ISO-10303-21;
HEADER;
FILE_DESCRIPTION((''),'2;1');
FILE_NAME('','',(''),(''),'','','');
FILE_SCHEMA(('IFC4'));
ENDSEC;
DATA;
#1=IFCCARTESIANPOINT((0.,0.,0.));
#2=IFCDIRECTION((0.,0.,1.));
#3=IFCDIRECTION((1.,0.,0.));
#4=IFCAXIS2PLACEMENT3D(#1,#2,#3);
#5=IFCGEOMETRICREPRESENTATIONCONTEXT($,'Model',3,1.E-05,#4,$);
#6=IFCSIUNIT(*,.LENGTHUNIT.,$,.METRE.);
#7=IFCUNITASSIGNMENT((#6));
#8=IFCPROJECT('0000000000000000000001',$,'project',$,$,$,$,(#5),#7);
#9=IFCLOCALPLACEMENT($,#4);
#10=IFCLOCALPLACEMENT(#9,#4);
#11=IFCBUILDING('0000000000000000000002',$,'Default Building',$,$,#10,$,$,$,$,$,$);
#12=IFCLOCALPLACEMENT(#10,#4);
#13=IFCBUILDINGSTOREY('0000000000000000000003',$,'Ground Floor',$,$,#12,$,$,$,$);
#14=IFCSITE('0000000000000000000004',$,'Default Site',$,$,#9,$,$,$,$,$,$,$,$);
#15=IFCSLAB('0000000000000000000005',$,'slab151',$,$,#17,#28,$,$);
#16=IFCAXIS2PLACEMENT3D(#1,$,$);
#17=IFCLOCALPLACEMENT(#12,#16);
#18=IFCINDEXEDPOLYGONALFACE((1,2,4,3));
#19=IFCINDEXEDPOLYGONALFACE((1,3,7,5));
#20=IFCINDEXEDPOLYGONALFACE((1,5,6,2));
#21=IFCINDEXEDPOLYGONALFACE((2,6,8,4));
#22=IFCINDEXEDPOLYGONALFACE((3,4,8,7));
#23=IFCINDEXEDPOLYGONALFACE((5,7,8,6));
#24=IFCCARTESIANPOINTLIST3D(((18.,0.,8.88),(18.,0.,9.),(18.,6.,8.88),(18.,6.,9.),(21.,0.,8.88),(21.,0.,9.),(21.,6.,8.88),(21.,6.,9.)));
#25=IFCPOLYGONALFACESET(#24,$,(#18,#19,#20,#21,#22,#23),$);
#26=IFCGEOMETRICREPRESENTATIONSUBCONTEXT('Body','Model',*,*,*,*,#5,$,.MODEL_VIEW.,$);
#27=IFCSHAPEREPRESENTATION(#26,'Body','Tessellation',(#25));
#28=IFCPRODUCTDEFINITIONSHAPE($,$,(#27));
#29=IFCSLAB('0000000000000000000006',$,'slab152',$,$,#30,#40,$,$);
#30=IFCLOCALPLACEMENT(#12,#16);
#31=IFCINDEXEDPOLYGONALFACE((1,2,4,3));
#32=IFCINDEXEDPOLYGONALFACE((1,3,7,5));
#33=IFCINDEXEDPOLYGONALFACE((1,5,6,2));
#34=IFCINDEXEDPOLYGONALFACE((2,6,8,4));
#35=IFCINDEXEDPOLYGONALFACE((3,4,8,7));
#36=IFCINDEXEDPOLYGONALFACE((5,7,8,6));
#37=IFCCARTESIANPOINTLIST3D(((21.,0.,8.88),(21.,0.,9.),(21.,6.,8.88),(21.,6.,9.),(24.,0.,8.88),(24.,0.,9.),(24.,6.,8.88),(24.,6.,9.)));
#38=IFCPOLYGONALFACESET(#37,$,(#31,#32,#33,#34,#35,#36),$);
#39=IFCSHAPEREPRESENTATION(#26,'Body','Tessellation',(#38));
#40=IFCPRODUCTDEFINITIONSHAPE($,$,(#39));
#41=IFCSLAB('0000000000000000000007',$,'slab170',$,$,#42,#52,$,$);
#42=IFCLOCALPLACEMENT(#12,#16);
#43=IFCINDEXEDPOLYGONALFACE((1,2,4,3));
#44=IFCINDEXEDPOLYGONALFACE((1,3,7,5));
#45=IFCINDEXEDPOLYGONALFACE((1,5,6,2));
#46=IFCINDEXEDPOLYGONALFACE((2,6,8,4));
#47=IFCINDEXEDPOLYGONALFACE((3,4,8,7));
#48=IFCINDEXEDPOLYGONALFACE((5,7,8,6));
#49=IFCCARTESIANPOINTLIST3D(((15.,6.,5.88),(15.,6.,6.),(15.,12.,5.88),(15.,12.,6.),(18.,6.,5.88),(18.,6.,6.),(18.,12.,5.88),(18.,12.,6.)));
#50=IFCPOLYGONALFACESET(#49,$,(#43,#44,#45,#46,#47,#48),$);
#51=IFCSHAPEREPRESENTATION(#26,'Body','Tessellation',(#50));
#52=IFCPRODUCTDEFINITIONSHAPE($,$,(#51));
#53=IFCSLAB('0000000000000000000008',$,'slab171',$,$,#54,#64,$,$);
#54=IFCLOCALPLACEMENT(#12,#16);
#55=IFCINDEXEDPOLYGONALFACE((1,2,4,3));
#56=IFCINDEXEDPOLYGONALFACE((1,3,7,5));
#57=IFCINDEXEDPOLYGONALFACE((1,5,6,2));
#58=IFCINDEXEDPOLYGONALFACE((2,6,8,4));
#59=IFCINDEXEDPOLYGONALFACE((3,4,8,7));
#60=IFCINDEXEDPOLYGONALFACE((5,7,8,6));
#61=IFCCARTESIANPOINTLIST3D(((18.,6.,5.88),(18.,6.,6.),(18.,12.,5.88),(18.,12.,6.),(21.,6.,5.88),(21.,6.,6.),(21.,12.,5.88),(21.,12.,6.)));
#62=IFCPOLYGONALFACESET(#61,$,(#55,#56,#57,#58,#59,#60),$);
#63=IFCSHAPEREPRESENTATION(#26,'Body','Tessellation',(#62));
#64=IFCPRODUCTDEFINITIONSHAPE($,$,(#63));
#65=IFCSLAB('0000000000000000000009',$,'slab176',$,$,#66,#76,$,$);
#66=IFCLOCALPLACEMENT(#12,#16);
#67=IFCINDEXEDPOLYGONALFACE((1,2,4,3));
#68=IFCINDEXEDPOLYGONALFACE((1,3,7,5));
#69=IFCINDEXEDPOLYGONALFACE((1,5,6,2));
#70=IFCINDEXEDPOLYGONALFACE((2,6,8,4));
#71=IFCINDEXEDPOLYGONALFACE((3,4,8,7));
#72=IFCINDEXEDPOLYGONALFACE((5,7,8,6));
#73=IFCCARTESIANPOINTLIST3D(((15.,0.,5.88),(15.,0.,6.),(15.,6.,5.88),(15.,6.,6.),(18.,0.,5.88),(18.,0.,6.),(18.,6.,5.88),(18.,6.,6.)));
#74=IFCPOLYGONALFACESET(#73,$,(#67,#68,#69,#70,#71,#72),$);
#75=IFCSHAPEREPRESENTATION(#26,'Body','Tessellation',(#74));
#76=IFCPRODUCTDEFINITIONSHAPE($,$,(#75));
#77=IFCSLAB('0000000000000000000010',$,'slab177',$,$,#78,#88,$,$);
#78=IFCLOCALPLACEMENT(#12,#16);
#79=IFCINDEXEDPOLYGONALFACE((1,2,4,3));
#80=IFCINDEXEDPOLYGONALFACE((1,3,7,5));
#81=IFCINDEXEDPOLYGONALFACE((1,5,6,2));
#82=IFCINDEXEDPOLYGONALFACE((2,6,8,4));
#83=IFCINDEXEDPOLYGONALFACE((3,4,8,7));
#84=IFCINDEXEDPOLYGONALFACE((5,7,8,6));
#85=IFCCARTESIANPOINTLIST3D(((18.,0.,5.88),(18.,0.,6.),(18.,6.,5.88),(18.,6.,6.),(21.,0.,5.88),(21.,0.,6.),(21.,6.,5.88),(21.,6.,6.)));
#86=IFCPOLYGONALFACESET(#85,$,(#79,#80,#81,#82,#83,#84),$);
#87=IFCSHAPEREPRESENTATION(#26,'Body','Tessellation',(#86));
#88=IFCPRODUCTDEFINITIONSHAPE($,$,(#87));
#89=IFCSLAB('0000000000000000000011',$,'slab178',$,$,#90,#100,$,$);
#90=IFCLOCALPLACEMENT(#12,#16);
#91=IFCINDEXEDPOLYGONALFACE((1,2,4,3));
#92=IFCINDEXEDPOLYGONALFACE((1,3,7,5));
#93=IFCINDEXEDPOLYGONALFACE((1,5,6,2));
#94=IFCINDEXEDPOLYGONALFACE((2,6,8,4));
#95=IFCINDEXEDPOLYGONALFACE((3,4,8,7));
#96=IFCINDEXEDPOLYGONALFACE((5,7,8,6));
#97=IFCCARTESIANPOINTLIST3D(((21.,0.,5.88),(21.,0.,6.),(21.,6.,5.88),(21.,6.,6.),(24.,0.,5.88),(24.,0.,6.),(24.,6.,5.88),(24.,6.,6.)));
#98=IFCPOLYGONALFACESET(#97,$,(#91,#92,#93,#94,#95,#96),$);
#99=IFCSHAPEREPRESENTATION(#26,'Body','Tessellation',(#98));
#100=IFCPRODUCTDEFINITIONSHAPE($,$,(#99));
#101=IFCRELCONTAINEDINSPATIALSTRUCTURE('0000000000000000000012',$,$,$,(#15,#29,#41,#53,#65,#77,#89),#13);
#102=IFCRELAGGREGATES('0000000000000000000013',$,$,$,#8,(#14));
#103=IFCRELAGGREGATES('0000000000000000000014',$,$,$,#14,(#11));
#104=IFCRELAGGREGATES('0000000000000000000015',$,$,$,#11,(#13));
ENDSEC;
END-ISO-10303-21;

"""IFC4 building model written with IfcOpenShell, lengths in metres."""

from ifc_helpers import new_model, si_unit, frame, origin_with_axes, place, context, subcontext, project, spatial, indexed_curve, outline, extrude, element, save


model = new_model("IFC4")

# Units and contexts
model_context = context("Model", 3, precision=1e-05, world=origin_with_axes())
body_context = subcontext(model_context, "Body", "Model", "MODEL_VIEW")
ifc_project = project(units=[si_unit("LENGTHUNIT", "METRE")], contexts=[model_context])

# Site, building, storey
site_placement = place(None, origin_with_axes())
site = spatial("IfcSite", under=ifc_project, at=site_placement, Name="Default Site")
building_placement = place(site_placement, origin_with_axes())
building = spatial("IfcBuilding", under=site, at=building_placement, Name="Default Building")
storey_placement = place(building_placement, origin_with_axes())
storey = spatial("IfcBuildingStorey", under=building, at=storey_placement, Name="Ground Floor")

# Slabs
for number, where, z_axis, x_axis, name in (
    (1, (18.0, 0.0, 8.88), (0.0, 0.0, 1.0), (1.0, 0.0, 0.0), "slab151"),
    (2, (21.0, 0.0, 8.88), (0.0, 0.0, 1.0), (1.0, 0.0, 0.0), "slab152"),
    (3, (15.0, 6.0, 5.88), (0.0, 0.0, 1.0), (1.0, 0.0, 0.0), "slab170"),
    (4, (18.0, 6.0, 5.88), (0.0, 0.0, 1.0), (1.0, 0.0, 0.0), "slab171"),
    (5, (15.0, 0.0, 5.88), (0.0, 0.0, 1.0), (1.0, 0.0, 0.0), "slab176"),
    (6, (18.0, 0.0, 5.88), (0.0, 0.0, 1.0), (1.0, 0.0, 0.0), "slab177"),
    (7, (21.0, 0.0, 5.88), (0.0, 0.0, 1.0), (1.0, 0.0, 0.0), "slab178"),
):
    element("IfcSlab", number, at=place(storey_placement, frame(where, z_axis=z_axis, x_axis=x_axis)), inside=storey, Name=name, context=body_context, shape_type="SweptSolid", body=[
        extrude(outline(indexed_curve([(0.0, 0.0), (0.0, 6.0), (3.0, 6.0), (3.0, 0.0), (0.0, 0.0)], self_intersect=False)), origin_with_axes(), (0.0, 0.0, 1.0), 0.12),
    ])

save(model, "model.ifc")
